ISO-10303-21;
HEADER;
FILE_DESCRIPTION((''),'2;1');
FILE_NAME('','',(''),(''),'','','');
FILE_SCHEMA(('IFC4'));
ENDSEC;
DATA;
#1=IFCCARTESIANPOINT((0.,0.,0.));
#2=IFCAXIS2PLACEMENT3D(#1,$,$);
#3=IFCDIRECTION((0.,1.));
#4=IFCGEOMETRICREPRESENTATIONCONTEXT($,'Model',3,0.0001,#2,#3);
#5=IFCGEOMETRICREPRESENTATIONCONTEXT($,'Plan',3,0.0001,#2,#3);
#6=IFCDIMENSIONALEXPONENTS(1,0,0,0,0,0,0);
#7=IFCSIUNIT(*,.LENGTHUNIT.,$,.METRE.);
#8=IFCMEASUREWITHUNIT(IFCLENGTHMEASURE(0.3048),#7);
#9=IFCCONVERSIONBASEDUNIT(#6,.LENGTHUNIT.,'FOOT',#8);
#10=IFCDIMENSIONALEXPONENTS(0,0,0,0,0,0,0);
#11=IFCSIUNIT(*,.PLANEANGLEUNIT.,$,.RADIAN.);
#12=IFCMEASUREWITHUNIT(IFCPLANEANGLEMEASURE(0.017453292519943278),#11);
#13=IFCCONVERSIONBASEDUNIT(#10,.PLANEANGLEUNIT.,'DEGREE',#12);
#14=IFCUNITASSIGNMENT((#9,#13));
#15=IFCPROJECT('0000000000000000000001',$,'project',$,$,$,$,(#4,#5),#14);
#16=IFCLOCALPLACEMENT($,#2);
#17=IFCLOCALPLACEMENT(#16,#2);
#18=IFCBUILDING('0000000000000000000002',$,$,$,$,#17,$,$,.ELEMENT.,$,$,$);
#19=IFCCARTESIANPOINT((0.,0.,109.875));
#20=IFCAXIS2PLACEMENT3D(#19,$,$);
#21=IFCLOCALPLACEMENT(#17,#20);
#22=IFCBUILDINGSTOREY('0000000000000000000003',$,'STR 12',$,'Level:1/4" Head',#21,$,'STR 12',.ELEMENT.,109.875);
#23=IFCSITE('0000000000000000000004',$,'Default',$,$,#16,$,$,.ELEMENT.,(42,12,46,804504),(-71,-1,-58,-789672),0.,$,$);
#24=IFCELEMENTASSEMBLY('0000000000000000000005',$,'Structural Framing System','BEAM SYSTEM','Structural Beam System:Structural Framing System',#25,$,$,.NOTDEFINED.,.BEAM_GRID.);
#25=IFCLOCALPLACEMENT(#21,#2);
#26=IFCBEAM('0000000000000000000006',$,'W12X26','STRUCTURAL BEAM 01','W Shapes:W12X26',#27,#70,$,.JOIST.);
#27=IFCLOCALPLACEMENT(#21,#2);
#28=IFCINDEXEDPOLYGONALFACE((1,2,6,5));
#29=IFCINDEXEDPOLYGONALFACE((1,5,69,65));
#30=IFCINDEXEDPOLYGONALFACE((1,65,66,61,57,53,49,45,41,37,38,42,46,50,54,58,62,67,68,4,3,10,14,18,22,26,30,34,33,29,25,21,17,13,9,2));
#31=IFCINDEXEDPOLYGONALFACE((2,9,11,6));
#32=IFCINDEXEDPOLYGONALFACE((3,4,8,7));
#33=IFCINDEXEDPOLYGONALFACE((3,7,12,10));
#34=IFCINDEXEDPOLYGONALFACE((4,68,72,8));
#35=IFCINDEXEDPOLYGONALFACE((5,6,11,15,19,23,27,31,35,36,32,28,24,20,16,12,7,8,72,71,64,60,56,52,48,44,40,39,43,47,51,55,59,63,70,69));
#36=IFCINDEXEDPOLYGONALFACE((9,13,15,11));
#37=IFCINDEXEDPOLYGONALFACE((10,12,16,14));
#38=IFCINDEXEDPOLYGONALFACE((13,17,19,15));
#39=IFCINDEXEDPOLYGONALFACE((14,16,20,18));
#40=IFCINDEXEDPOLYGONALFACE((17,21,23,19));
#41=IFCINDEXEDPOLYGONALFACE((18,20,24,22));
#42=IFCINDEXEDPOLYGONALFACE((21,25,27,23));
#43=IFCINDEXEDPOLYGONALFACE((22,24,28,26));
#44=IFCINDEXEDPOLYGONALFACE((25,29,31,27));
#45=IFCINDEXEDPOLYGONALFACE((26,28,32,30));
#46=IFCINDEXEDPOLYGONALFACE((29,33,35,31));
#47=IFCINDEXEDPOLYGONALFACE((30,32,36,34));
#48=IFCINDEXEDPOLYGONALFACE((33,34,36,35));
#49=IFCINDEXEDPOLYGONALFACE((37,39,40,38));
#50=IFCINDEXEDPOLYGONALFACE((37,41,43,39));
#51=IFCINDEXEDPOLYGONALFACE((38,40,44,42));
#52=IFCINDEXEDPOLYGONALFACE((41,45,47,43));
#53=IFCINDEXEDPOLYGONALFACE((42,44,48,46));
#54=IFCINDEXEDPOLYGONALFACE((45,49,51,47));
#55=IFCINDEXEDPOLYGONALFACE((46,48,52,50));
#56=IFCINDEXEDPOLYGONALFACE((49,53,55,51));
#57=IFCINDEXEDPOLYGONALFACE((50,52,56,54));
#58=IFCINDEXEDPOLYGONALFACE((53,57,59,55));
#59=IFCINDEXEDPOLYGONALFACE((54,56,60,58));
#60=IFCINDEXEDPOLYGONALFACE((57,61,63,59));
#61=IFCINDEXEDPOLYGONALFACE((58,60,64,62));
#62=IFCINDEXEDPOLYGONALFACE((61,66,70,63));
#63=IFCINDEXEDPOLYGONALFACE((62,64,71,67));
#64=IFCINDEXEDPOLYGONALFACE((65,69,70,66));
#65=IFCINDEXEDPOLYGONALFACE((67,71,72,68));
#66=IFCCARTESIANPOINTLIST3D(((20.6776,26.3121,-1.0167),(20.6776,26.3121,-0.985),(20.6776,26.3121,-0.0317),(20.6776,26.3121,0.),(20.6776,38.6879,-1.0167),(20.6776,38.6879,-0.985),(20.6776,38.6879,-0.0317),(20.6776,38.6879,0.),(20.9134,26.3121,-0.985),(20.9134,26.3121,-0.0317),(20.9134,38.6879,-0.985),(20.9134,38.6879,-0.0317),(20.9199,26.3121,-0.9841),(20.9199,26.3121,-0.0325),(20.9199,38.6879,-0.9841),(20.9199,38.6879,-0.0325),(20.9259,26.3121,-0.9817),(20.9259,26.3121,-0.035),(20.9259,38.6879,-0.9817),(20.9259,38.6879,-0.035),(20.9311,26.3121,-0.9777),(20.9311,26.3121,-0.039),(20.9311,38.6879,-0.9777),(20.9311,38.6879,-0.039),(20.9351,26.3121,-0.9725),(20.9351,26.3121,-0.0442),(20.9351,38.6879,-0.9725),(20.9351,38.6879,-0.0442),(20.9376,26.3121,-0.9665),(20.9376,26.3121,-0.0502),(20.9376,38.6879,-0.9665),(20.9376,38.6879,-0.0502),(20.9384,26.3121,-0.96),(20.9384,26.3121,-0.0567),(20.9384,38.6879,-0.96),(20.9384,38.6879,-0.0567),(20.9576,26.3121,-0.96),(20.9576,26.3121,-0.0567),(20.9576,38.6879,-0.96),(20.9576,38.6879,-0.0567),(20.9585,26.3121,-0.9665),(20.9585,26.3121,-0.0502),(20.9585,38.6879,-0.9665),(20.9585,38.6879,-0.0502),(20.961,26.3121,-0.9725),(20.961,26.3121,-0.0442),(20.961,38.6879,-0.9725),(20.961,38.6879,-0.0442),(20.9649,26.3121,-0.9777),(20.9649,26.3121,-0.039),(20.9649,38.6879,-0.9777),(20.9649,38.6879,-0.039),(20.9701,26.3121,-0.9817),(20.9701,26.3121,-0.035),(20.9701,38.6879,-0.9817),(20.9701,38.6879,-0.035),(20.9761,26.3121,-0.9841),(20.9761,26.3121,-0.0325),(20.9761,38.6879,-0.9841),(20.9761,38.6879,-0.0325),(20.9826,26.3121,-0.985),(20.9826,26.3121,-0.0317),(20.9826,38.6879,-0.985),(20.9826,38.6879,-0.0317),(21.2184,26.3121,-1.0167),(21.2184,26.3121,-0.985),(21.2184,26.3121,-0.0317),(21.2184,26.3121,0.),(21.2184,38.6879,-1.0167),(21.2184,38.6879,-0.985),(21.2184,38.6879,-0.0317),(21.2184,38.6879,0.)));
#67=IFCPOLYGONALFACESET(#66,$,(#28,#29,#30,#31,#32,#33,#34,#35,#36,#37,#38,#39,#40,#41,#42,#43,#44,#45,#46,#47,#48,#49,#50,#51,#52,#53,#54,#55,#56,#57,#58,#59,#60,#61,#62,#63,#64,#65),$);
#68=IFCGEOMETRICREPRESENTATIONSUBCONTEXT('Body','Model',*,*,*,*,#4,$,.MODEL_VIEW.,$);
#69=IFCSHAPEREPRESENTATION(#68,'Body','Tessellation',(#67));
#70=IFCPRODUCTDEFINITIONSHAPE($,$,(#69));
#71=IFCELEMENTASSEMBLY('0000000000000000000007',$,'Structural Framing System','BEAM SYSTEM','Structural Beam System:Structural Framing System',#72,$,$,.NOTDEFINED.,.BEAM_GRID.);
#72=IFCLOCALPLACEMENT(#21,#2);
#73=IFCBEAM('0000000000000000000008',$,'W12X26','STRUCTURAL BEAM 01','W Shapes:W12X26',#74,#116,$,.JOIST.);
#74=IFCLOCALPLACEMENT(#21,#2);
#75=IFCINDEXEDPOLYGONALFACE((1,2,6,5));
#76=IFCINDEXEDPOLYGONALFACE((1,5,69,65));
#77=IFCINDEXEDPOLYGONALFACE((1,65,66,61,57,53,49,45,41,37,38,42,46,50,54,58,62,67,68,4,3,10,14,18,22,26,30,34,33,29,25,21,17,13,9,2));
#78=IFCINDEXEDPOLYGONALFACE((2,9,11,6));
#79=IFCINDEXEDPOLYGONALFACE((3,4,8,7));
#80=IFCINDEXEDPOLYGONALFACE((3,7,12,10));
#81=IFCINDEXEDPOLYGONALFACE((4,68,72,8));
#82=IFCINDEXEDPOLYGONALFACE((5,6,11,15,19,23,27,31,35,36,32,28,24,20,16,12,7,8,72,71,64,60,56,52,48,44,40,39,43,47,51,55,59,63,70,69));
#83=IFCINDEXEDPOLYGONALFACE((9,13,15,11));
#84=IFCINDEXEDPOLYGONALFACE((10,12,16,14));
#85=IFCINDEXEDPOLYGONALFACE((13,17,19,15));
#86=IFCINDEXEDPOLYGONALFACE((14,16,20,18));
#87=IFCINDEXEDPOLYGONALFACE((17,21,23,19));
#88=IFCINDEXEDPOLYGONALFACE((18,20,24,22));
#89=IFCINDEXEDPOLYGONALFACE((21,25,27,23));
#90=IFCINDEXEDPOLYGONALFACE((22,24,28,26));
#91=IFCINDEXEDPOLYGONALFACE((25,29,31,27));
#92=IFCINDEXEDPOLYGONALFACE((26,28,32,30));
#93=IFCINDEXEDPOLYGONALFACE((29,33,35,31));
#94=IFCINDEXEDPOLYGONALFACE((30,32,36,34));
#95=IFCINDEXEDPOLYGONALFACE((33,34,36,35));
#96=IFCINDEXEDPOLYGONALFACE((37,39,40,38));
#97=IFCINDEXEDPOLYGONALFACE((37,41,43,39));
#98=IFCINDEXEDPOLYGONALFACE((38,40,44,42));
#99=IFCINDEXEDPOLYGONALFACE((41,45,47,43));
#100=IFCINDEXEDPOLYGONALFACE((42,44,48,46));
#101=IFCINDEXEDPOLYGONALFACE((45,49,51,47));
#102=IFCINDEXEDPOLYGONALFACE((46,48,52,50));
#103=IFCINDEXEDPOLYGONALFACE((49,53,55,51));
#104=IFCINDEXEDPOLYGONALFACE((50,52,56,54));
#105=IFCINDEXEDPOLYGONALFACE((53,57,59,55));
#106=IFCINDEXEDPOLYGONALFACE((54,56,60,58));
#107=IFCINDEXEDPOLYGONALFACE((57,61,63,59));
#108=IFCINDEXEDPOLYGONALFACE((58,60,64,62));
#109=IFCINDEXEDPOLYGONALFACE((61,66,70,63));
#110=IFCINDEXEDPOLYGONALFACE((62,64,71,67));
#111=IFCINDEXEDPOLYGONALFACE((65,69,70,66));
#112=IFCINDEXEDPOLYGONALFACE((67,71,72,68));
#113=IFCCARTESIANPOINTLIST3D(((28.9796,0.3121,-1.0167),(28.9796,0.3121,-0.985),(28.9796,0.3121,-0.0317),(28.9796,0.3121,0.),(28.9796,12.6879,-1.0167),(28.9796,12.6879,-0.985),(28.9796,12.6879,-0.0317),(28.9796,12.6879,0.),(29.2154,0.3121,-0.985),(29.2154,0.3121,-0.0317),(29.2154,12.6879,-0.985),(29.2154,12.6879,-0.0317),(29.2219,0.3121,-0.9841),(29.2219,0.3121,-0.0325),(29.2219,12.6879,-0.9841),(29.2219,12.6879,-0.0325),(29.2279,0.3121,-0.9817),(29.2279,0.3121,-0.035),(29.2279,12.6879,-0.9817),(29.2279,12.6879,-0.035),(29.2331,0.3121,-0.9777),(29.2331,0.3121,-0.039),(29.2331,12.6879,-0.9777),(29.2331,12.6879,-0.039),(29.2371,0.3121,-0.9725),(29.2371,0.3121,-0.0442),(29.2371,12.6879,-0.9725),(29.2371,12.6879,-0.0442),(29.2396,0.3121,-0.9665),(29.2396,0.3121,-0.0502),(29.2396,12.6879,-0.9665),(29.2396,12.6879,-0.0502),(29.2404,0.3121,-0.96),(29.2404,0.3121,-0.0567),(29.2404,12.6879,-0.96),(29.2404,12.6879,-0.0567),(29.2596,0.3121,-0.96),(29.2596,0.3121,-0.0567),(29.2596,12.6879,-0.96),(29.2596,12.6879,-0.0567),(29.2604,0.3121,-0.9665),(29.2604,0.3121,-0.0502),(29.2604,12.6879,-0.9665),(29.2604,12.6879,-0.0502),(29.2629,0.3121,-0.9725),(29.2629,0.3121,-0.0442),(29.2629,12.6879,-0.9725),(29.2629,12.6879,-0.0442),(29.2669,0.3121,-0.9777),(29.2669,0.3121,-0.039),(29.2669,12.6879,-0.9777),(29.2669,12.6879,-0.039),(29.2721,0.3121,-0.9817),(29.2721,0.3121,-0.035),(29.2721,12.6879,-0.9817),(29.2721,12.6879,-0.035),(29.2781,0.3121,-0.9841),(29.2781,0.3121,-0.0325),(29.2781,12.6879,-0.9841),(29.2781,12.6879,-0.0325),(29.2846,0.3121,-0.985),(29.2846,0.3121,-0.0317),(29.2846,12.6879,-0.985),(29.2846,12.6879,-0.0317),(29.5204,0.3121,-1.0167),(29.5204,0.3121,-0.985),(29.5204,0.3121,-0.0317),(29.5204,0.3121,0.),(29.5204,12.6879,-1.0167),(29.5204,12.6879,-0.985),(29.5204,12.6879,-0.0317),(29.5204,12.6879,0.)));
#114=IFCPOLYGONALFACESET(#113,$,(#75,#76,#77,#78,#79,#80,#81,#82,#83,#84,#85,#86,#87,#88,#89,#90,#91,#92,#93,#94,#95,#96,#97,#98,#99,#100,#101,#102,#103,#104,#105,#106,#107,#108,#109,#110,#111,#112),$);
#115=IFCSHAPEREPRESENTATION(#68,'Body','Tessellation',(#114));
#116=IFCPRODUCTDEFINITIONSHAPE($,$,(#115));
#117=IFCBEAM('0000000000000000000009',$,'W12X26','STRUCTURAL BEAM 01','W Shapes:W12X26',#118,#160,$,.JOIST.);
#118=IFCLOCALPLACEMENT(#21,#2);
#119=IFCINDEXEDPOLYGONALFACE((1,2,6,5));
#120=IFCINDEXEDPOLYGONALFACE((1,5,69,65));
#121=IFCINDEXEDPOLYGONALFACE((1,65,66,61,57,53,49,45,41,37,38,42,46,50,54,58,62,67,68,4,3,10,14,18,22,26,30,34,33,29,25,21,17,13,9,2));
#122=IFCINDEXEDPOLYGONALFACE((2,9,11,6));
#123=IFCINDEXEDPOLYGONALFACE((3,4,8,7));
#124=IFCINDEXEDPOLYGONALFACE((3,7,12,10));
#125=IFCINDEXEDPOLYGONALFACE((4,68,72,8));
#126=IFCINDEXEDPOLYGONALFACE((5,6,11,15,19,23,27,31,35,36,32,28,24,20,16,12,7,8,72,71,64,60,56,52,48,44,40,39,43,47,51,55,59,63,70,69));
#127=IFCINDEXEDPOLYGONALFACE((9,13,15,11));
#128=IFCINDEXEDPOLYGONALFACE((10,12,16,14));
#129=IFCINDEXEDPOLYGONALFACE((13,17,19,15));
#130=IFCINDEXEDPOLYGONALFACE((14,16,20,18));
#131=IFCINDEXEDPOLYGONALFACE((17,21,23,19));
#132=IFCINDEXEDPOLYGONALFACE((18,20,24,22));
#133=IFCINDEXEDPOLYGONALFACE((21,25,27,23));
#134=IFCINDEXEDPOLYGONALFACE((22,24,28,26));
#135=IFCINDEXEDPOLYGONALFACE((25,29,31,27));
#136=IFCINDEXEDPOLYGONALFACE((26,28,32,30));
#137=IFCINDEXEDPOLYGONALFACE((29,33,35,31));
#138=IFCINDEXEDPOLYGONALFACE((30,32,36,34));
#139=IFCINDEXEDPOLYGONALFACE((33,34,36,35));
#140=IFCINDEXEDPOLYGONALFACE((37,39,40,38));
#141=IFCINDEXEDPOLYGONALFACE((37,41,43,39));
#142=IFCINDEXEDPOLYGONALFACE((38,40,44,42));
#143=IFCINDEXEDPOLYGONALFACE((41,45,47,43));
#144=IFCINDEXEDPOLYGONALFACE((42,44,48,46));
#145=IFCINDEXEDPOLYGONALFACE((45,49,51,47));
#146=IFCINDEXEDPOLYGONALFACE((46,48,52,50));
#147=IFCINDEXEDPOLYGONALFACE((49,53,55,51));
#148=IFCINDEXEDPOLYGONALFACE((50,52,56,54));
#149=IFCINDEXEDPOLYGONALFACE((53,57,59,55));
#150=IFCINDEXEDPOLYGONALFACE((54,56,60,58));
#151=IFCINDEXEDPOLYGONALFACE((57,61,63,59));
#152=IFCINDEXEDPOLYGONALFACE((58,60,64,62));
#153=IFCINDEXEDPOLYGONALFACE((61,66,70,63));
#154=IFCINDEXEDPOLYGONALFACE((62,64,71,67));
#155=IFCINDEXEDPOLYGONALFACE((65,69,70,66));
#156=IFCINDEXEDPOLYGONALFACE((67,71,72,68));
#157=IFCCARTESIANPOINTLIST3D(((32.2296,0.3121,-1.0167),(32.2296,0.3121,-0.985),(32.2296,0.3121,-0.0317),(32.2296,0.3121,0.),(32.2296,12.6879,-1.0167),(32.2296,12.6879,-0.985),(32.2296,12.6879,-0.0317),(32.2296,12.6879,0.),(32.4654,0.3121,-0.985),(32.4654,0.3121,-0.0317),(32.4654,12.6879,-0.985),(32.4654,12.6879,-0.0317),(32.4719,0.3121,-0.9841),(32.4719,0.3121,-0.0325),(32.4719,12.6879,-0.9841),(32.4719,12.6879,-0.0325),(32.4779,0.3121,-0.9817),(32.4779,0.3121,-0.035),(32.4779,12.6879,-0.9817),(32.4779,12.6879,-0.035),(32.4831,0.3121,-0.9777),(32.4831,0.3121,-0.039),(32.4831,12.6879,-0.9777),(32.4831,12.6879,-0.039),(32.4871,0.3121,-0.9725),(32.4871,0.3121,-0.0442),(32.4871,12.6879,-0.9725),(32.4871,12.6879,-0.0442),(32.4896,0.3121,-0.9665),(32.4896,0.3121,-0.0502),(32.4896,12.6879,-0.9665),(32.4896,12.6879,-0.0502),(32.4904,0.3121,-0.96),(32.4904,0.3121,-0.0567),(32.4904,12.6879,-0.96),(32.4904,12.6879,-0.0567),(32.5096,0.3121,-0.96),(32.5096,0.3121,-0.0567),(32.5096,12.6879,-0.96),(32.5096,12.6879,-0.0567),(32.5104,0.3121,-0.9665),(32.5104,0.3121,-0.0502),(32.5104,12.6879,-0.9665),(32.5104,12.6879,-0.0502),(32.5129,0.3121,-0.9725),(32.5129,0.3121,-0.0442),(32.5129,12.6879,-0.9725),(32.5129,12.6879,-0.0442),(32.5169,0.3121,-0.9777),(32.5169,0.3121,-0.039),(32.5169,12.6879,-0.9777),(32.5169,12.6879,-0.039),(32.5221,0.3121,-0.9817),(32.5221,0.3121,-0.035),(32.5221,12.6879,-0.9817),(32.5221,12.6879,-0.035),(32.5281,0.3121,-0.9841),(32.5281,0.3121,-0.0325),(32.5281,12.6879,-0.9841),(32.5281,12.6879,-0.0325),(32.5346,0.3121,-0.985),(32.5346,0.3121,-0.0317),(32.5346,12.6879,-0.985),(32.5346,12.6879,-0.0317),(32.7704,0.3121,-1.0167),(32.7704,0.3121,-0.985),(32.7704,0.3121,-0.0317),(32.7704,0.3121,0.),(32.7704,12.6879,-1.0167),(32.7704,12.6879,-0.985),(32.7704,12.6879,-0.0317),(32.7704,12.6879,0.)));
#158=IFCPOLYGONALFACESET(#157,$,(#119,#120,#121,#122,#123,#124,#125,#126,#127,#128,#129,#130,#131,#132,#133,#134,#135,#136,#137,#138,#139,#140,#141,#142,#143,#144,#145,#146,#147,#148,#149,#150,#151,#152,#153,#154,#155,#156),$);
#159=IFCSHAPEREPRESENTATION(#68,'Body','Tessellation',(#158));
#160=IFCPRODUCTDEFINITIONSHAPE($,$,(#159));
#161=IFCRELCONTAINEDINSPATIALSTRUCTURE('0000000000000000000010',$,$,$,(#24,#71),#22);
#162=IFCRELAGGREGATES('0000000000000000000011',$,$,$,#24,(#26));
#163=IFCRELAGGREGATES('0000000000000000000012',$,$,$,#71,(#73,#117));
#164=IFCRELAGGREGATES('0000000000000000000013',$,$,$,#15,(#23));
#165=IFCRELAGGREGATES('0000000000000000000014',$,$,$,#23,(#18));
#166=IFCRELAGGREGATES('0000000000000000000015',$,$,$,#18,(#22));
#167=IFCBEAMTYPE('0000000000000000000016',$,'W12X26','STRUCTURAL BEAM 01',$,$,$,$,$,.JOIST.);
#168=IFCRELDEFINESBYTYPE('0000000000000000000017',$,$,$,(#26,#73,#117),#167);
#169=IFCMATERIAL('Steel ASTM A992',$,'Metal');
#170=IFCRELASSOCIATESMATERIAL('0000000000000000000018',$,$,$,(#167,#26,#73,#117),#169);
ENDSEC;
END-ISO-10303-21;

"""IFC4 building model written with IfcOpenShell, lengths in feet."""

from ifc_helpers import new_model, entity, si_unit, converted_unit, direction, frame, origin, place, context, subcontext, project, spatial, line, arc, indexed_curve, outline, extrude, source, transform, mapped, material, type_object, type_shapes, element, aggregate, save


model = new_model("IFC4")

# Units and contexts
model_context = context("Model", 3, precision=0.0001, world=origin(), true_north=direction((0.0, 1.0)))
plan_context = context("Plan", 3, precision=0.0001, world=origin(), true_north=direction((0.0, 1.0)))
body_context = subcontext(model_context, "Body", "Model", "MODEL_VIEW")
ifc_project = project(units=[converted_unit("LENGTHUNIT", "FOOT", entity("IfcLengthMeasure", 0.3048), si_unit("LENGTHUNIT", "METRE"), dimensions=[1, 0, 0, 0, 0, 0, 0]), converted_unit("PLANEANGLEUNIT", "DEGREE", entity("IfcPlaneAngleMeasure", 0.017453292519943278), si_unit("PLANEANGLEUNIT", "RADIAN"), dimensions=[0, 0, 0, 0, 0, 0, 0])], contexts=[model_context, plan_context])

# Site, building, storey
site_placement = place(None, origin())
site = spatial("IfcSite", under=ifc_project, at=site_placement, Name="Default", CompositionType="ELEMENT", RefLatitude=(42, 12, 46, 804504), RefLongitude=(-71, -1, -58, -789672), RefElevation=0.0)
building_placement = place(site_placement, origin())
building = spatial("IfcBuilding", under=site, at=building_placement, CompositionType="ELEMENT")
storey_placement = place(building_placement, frame((0.0, 0.0, 109.875)))
storey = spatial("IfcBuildingStorey", under=building, at=storey_placement, Name="STR 12", ObjectType="Level:1/4\" Head", LongName="STR 12", CompositionType="ELEMENT", Elevation=109.875)

# Element assemblies, beams
ifc_material = material(Name="Steel ASTM A992", Category="Metal")
beam_type = type_object("IfcBeamType", Name="W12X26", Description="STRUCTURAL BEAM 01", PredefinedType="JOIST", material=ifc_material)
shared_shape = source(origin(), body_context, "Body", "SweptSolid", [
    extrude(outline(indexed_curve([(-0.2704, -0.4767), (-0.2704, -0.5083), (0.2704, -0.5083), (0.2704, -0.4767), (0.0346, -0.4767), (0.0169, -0.4693), (0.0096, -0.4517), (0.0096, 0.4517), (0.0169, 0.4693), (0.0346, 0.4767), (0.2704, 0.4767), (0.2704, 0.5083), (-0.2704, 0.5083), (-0.2704, 0.4767), (-0.0346, 0.4767), (-0.0169, 0.4693), (-0.0096, 0.4517), (-0.0096, -0.4517), (-0.0169, -0.4693), (-0.0346, -0.4767)], segments=[line(1, 2, 3, 4, 5), arc(5, 6, 7), line(7, 8), arc(8, 9, 10), line(10, 11, 12, 13, 14, 15), arc(15, 16, 17), line(17, 18), arc(18, 19, 20), line(20, 1)], self_intersect=False)), frame((-6.1879, 0.0, 0.0), z_axis=(-1.0, 0.0, 0.0), x_axis=(0.0, -1.0, 0.0)), (0.0, 0.0, -1.0), 12.3758),
])
type_shapes(beam_type, [shared_shape])
assembly_1_placement = place(storey_placement, origin())
assembly_1 = element("IfcElementAssembly", 1, at=assembly_1_placement, inside=storey, Name="Structural Framing System", Description="BEAM SYSTEM", ObjectType="Structural Beam System:Structural Framing System", AssemblyPlace="NOTDEFINED", PredefinedType="BEAM_GRID")
beam_1_placement = place(assembly_1_placement, frame((20.948, 32.5, -0.5083), z_axis=(0.0, 0.0, 1.0), x_axis=(0.0, 1.0, 0.0)))
beam_1 = element("IfcBeam", 2, at=beam_1_placement, type_object=beam_type, material=ifc_material, Name="W12X26", Description="STRUCTURAL BEAM 01", ObjectType="W Shapes:W12X26", PredefinedType="JOIST", context=body_context, shape_type="MappedRepresentation", body=[
    mapped(shared_shape, transform((0.0, 0.0, 0.0), scale=1.0)),
])
aggregate(assembly_1, [beam_1])
assembly_2_placement = place(storey_placement, origin())
assembly_2 = element("IfcElementAssembly", 3, at=assembly_2_placement, inside=storey, Name="Structural Framing System", Description="BEAM SYSTEM", ObjectType="Structural Beam System:Structural Framing System", AssemblyPlace="NOTDEFINED", PredefinedType="BEAM_GRID")
beam_2_placement = place(assembly_2_placement, frame((29.25, 6.5, -0.5083), z_axis=(0.0, 0.0, 1.0), x_axis=(0.0, 1.0, 0.0)))
beam_2 = element("IfcBeam", 4, at=beam_2_placement, type_object=beam_type, material=ifc_material, Name="W12X26", Description="STRUCTURAL BEAM 01", ObjectType="W Shapes:W12X26", PredefinedType="JOIST", context=body_context, shape_type="MappedRepresentation", body=[
    mapped(shared_shape, transform((0.0, 0.0, 0.0), scale=1.0)),
])
beam_3_placement = place(assembly_2_placement, frame((32.5, 6.5, -0.5083), z_axis=(0.0, 0.0, 1.0), x_axis=(0.0, 1.0, 0.0)))
beam_3 = element("IfcBeam", 5, at=beam_3_placement, type_object=beam_type, material=ifc_material, Name="W12X26", Description="STRUCTURAL BEAM 01", ObjectType="W Shapes:W12X26", PredefinedType="JOIST", context=body_context, shape_type="MappedRepresentation", body=[
    mapped(shared_shape, transform((0.0, 0.0, 0.0), scale=1.0)),
])
aggregate(assembly_2, [beam_2, beam_3])

save(model, "model.ifc")
